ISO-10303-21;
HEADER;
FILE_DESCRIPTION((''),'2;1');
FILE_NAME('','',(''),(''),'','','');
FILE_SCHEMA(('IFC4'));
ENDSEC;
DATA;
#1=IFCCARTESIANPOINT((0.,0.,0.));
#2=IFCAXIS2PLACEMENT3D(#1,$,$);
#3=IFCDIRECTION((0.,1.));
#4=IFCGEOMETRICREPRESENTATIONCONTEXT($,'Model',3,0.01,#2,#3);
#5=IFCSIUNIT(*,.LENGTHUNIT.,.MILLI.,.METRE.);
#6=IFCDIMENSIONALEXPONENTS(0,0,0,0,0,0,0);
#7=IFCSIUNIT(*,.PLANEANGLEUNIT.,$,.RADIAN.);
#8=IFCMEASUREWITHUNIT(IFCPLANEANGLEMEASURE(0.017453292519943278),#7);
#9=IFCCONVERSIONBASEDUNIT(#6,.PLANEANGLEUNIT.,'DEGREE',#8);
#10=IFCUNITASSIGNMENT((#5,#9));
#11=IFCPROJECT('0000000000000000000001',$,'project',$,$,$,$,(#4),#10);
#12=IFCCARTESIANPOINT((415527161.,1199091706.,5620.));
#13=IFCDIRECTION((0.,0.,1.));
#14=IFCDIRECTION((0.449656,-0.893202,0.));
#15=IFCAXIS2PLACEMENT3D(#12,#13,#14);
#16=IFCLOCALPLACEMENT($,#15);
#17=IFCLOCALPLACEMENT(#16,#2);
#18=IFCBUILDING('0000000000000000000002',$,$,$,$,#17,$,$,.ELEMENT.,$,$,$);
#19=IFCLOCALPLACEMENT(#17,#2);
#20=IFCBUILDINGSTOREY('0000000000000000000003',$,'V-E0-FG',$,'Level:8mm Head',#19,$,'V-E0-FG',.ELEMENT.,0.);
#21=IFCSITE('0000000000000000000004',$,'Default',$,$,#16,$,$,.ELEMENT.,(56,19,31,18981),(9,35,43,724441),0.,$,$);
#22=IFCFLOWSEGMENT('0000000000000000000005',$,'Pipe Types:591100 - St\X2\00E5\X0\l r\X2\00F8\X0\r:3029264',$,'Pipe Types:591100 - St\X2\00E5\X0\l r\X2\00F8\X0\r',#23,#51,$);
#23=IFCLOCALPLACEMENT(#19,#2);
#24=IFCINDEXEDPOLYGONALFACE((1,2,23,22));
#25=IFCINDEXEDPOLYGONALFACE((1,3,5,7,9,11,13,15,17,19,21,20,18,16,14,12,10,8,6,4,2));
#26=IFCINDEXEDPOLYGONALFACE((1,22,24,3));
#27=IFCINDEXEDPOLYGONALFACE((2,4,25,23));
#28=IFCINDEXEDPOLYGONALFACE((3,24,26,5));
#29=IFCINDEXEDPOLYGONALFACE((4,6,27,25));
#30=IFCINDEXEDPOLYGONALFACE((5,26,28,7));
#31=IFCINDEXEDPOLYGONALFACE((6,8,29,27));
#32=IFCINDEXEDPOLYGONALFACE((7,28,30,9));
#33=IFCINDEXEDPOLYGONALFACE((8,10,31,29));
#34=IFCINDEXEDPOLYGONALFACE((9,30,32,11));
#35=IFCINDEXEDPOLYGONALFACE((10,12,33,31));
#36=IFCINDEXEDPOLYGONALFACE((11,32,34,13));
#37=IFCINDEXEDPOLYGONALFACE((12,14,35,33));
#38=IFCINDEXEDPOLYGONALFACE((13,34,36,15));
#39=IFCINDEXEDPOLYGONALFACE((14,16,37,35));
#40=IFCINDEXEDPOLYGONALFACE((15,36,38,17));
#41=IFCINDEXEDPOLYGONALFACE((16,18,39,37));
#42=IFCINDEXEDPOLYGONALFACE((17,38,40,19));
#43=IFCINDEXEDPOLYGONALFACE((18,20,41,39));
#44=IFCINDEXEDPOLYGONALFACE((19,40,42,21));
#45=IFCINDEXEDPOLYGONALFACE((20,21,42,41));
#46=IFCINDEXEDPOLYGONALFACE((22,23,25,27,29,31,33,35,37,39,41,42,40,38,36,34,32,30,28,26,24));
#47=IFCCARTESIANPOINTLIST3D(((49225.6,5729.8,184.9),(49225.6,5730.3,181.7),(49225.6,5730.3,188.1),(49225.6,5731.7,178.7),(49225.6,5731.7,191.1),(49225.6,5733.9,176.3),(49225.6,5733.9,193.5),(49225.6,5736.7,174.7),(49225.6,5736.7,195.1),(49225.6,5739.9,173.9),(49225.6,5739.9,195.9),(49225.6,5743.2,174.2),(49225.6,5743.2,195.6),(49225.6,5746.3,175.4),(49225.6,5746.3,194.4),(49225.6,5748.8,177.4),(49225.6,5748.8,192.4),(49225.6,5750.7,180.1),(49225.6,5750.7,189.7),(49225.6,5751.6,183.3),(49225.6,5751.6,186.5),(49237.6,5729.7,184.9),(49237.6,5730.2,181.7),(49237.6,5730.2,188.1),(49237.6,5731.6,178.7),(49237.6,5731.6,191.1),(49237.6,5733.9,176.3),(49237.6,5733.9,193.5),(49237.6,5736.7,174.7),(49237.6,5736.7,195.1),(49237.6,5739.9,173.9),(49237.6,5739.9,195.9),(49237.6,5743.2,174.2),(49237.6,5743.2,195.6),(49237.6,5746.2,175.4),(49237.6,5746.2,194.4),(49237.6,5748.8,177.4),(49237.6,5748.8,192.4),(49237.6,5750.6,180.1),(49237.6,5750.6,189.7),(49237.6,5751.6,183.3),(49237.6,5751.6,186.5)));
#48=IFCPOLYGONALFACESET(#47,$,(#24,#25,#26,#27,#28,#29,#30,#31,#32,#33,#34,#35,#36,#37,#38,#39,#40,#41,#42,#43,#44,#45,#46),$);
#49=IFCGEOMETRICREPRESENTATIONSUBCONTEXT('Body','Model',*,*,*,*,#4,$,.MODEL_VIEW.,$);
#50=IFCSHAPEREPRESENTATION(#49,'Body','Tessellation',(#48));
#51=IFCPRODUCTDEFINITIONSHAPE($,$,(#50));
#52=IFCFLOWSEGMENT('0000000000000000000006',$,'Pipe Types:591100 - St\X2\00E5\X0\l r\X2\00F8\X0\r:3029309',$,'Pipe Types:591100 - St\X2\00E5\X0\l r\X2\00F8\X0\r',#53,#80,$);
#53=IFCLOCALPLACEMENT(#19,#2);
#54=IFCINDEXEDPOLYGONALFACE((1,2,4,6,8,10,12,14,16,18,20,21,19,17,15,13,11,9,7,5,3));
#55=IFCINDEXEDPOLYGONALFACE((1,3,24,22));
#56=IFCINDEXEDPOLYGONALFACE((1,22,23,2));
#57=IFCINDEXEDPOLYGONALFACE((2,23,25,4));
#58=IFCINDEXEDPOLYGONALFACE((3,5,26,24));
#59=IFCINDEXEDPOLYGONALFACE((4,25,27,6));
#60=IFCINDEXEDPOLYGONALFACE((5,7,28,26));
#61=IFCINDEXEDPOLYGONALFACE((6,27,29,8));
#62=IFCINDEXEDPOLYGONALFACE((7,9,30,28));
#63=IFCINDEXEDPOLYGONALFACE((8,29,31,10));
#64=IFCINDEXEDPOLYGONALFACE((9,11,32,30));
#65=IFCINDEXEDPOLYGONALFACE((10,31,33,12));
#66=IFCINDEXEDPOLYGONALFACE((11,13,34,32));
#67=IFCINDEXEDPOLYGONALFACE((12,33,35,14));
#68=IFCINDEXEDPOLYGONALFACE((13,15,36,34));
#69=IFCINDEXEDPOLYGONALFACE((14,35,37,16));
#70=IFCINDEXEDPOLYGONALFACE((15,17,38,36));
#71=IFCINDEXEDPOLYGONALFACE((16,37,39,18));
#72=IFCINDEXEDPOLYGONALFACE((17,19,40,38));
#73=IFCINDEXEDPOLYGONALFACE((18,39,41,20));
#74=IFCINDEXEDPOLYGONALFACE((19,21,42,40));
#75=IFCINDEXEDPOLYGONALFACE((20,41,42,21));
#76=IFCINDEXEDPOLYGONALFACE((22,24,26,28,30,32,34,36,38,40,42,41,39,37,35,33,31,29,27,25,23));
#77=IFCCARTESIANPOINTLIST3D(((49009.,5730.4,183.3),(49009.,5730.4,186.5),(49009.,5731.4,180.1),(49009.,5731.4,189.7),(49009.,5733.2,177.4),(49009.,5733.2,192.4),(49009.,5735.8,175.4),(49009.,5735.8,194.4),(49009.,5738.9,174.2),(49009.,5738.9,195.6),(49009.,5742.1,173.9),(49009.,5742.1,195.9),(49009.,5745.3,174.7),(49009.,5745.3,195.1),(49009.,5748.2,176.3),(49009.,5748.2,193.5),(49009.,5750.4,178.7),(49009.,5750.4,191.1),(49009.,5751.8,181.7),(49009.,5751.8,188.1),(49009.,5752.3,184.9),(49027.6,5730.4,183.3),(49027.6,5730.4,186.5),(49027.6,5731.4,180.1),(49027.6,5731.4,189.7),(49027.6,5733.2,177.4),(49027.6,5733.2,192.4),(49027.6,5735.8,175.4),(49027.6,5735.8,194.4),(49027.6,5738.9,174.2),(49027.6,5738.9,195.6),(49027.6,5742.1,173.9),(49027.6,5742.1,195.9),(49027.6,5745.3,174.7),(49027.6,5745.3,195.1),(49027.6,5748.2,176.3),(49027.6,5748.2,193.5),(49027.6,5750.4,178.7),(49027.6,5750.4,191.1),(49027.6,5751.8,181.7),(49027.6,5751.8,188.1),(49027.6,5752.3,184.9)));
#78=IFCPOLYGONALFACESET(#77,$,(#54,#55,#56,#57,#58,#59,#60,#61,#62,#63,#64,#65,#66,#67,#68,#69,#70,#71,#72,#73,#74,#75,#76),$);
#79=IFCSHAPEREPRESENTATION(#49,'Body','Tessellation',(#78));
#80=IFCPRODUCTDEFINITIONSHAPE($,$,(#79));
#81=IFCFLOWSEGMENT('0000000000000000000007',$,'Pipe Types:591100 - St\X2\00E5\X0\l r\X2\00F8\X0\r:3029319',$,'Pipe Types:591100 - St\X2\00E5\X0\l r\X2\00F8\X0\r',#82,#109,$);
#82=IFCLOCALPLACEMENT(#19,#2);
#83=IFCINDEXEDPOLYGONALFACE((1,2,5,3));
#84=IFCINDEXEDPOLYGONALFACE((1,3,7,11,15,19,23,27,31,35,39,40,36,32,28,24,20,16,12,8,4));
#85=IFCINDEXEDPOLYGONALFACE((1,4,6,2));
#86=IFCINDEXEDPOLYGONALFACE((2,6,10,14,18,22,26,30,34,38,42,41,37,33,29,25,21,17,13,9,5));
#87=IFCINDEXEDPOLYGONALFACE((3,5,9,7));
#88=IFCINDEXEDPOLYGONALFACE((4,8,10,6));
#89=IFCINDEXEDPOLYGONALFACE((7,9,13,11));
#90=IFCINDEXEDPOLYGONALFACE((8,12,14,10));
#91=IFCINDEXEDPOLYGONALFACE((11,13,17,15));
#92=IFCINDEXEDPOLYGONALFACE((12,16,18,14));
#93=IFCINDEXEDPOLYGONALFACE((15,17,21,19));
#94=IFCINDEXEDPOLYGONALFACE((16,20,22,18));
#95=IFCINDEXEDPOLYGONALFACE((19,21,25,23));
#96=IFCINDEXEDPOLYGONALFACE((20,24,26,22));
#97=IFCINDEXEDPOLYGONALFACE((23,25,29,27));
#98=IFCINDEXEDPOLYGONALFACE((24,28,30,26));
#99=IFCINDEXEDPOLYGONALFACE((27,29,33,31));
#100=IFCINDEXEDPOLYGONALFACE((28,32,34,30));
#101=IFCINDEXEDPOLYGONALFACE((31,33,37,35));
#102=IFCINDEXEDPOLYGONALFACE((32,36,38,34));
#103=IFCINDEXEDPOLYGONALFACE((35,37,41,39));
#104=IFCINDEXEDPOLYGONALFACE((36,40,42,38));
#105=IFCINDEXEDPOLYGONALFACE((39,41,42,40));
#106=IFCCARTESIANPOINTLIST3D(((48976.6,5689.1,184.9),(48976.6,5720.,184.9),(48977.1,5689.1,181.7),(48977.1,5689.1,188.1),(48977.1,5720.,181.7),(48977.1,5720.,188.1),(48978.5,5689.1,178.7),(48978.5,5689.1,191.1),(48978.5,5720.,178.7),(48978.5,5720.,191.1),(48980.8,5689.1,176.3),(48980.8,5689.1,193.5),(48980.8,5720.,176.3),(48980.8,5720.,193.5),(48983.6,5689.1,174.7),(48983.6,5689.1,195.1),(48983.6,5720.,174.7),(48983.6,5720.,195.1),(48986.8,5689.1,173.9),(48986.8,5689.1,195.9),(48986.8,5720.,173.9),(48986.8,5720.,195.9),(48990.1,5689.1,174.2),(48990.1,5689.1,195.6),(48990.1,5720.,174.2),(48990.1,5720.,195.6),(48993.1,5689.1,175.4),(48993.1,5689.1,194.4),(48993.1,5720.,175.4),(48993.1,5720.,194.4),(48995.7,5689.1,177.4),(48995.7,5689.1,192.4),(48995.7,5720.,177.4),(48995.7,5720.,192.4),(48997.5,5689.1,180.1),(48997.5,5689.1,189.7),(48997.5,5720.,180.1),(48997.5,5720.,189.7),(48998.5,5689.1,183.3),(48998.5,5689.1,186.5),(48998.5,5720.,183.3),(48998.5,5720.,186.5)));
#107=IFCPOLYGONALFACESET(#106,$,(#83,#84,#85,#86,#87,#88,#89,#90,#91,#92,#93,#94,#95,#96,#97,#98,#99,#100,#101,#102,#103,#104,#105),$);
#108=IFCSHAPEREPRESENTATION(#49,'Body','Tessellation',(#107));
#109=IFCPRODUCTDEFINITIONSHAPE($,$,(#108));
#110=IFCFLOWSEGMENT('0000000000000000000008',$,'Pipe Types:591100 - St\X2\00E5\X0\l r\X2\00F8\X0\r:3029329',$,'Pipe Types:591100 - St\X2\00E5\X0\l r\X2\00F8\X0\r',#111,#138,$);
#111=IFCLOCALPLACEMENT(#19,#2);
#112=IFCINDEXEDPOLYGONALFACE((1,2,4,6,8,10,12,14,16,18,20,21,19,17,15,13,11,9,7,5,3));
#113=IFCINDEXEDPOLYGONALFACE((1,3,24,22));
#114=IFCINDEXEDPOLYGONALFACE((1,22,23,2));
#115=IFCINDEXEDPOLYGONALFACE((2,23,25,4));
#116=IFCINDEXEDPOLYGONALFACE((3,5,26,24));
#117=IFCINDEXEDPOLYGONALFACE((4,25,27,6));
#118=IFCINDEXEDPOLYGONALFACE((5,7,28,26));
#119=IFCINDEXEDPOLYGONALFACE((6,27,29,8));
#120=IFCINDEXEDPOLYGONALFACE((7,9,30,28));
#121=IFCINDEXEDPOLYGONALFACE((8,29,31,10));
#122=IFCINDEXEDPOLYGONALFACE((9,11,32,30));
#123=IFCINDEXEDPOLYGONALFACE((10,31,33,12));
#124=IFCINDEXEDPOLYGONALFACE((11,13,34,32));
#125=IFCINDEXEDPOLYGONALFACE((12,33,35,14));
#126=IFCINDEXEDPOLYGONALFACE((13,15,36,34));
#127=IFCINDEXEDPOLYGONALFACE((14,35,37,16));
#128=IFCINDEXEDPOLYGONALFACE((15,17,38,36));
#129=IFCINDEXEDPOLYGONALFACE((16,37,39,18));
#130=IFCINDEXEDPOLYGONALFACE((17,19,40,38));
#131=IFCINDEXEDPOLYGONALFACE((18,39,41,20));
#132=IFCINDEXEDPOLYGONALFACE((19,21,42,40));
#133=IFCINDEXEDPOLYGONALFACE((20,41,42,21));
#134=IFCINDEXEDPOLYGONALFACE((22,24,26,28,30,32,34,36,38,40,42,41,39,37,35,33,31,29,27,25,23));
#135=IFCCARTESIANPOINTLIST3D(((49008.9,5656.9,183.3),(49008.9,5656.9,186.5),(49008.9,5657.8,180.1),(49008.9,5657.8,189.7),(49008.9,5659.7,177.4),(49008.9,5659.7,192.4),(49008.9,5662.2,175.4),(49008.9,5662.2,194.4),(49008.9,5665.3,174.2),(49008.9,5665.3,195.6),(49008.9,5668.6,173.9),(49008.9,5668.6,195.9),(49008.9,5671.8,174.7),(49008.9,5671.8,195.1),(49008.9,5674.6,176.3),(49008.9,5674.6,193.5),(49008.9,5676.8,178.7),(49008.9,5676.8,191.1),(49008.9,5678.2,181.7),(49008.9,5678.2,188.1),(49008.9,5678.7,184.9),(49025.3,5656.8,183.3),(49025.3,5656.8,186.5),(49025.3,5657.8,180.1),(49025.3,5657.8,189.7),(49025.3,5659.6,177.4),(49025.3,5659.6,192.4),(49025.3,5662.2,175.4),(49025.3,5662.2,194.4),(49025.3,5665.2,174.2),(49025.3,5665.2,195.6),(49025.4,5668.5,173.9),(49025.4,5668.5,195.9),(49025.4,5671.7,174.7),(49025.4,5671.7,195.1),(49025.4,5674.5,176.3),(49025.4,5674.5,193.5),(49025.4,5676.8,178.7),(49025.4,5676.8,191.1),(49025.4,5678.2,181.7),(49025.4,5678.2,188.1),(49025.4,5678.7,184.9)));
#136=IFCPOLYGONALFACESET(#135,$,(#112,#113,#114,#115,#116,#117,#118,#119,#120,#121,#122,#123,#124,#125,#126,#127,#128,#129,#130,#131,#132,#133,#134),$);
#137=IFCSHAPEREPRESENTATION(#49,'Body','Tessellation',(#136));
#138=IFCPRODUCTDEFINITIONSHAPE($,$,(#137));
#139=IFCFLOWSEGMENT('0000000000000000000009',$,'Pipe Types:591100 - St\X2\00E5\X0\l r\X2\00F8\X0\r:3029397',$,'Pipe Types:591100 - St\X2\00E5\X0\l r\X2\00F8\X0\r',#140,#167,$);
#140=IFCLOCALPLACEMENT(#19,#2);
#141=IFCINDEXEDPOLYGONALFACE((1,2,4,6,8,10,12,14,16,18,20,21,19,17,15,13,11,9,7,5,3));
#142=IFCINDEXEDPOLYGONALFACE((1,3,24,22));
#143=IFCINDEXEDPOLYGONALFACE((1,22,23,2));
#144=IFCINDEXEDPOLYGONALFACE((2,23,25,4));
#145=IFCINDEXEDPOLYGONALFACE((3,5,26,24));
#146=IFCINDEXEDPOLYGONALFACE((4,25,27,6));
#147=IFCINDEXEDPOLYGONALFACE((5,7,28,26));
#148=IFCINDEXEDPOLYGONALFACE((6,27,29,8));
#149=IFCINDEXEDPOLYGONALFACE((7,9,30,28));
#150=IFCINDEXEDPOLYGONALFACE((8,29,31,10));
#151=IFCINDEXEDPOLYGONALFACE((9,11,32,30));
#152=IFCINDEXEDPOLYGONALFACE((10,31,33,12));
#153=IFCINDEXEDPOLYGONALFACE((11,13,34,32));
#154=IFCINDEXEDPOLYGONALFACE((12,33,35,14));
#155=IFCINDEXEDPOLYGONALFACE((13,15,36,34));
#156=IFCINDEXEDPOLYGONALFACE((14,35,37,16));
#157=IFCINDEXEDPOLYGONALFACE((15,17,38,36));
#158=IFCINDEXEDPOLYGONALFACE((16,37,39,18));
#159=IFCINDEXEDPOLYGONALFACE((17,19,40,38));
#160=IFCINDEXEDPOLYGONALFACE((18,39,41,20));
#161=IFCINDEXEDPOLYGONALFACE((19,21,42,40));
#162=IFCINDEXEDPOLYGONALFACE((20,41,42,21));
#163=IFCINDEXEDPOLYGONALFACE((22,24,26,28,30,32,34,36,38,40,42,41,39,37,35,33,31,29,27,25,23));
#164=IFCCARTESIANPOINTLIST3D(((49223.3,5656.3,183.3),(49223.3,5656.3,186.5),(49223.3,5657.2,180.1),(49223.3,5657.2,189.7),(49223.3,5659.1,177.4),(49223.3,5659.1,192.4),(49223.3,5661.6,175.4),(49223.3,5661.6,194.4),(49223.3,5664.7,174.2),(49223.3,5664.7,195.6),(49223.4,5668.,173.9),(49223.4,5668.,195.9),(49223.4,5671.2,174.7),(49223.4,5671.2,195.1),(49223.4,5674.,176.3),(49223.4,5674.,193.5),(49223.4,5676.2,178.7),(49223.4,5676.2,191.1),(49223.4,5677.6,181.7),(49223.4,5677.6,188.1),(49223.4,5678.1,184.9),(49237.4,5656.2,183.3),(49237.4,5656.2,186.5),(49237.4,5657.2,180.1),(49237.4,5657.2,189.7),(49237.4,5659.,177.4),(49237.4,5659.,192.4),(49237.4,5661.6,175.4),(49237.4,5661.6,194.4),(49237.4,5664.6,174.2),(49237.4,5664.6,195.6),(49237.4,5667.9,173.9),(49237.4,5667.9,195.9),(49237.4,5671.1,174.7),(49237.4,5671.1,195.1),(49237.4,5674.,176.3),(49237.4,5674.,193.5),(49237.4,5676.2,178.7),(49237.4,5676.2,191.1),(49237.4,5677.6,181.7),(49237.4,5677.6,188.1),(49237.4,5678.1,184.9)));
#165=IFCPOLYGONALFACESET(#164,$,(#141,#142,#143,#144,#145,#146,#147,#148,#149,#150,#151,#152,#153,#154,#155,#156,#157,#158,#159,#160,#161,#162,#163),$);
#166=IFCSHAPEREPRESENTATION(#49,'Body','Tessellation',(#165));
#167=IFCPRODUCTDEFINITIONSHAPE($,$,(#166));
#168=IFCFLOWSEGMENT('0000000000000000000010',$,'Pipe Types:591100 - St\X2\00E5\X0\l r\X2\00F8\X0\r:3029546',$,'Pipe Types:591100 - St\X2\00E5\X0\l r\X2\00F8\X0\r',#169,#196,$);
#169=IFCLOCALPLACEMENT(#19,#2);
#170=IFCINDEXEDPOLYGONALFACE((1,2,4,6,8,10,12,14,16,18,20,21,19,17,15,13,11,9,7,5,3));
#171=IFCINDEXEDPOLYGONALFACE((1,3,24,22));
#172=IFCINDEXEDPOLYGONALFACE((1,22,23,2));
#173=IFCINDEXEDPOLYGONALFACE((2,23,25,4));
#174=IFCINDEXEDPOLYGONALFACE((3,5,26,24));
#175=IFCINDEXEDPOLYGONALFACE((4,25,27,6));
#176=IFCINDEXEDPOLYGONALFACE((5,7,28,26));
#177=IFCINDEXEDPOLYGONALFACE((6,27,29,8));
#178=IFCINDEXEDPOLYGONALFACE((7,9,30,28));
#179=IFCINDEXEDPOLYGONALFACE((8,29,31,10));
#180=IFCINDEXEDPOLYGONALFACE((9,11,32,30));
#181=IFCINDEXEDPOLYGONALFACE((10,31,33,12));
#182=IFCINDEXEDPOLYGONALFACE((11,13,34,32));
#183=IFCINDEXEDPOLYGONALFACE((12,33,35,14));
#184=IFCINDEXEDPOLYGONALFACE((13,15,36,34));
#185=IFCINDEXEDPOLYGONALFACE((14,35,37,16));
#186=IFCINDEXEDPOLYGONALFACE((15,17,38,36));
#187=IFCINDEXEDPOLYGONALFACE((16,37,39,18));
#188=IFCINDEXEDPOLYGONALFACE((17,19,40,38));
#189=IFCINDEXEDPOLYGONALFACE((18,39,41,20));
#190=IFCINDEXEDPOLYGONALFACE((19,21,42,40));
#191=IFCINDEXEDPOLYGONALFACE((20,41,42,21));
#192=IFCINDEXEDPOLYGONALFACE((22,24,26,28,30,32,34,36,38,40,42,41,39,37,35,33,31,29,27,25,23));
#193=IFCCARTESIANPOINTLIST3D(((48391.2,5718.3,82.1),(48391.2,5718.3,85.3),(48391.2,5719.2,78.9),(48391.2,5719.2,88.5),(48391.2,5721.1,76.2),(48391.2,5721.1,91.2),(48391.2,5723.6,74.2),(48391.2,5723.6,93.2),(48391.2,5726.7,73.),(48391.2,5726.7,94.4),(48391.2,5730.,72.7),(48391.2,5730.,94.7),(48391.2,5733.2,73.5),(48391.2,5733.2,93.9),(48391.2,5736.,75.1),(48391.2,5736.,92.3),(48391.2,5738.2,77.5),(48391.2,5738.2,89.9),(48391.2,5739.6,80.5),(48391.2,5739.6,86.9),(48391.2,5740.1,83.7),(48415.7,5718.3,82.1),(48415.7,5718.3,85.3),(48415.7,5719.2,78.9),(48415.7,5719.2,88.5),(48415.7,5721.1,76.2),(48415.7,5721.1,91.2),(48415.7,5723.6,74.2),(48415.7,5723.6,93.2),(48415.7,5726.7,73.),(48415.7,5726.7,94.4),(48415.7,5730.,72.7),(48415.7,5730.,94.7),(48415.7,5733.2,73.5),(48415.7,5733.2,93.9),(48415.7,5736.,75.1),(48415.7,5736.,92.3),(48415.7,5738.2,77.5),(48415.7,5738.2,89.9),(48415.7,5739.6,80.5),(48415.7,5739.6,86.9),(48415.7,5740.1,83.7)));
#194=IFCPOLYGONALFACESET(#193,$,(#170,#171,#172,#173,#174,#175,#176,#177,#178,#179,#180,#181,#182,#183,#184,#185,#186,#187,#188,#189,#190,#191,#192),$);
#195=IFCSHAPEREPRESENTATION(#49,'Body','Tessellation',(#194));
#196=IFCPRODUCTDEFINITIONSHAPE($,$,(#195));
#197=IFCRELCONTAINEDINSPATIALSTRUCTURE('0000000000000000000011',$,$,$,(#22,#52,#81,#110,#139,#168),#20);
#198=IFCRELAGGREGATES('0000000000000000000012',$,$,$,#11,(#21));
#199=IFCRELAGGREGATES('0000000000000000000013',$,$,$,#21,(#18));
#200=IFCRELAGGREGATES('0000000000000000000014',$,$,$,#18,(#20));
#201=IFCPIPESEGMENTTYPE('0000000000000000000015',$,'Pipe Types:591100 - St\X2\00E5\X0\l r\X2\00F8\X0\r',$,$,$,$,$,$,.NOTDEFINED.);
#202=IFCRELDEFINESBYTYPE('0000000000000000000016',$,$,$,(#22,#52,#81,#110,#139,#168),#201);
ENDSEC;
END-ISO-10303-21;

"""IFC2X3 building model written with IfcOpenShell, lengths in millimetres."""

from ifc_helpers import new_model, entity, si_unit, converted_unit, direction, frame, frame_2d, origin, origin_2d_with_axis, place, context, subcontext, project, spatial, circle, extrude, type_object, element, save


model = new_model("IFC2X3")

# Units and contexts
model_context = context("Model", 3, precision=0.01, world=origin(), true_north=direction((0.0, 1.0)))
body_context = subcontext(model_context, "Body", "Model", "MODEL_VIEW")
ifc_project = project(units=[si_unit("LENGTHUNIT", "METRE", prefix="MILLI"), converted_unit("PLANEANGLEUNIT", "DEGREE", entity("IfcPlaneAngleMeasure", 0.017453292519943278), si_unit("PLANEANGLEUNIT", "RADIAN"), dimensions=[0, 0, 0, 0, 0, 0, 0])], contexts=[model_context])

# Site, building, storey
site_placement = place(None, frame((415527161.0, 1199091706.0, 5620.0), z_axis=(0.0, 0.0, 1.0), x_axis=(0.449656, -0.893202, 0.0)))
site = spatial("IfcSite", under=ifc_project, at=site_placement, Name="Default", CompositionType="ELEMENT", RefLatitude=(56, 19, 31, 18981), RefLongitude=(9, 35, 43, 724441), RefElevation=0.0)
building_placement = place(site_placement, origin())
building = spatial("IfcBuilding", under=site, at=building_placement, CompositionType="ELEMENT")
storey_placement = place(building_placement, origin())
storey = spatial("IfcBuildingStorey", under=building, at=storey_placement, Name="V-E0-FG", ObjectType="Level:8mm Head", LongName="V-E0-FG", CompositionType="ELEMENT", Elevation=0.0)

# Flow segments
pipe_segment_type_1 = type_object("IfcPipeSegmentType", Name="Pipe Types:591100 - Stål rør", PredefinedType="NOTDEFINED")
flow_segment_1_placement = place(storey_placement, origin())
element("IfcFlowSegment", 1, at=flow_segment_1_placement, inside=storey, type_object=pipe_segment_type_1, Name="Pipe Types:591100 - Stål rør:3029264", ObjectType="Pipe Types:591100 - Stål rør", context=body_context, shape_type="SweptSolid", body=[
    extrude(circle(Radius=11.0, at=origin_2d_with_axis()), frame((49225.6, 5740.8, 184.9), z_axis=(0.999996, -0.002778, 0.0), x_axis=(-0.002778, -0.999996, 0.0)), (0.0, 0.0, 1.0), 12.0),
])
flow_segment_2_placement = place(storey_placement, origin())
element("IfcFlowSegment", 2, at=flow_segment_2_placement, inside=storey, type_object=pipe_segment_type_1, Name="Pipe Types:591100 - Stål rør:3029309", ObjectType="Pipe Types:591100 - Stål rør", context=body_context, shape_type="SweptSolid", body=[
    extrude(circle(Radius=11.0, at=frame_2d((0.0, 0.0), x_axis=(1.0, 0.0))), frame((49009.0, 5741.3, 184.9), z_axis=(1.0, 0.0, 0.0), x_axis=(0.0, 1.0, 0.0)), (0.0, 0.0, 1.0), 18.7),
])
flow_segment_3_placement = place(storey_placement, origin())
element("IfcFlowSegment", 3, at=flow_segment_3_placement, inside=storey, type_object=pipe_segment_type_1, Name="Pipe Types:591100 - Stål rør:3029319", ObjectType="Pipe Types:591100 - Stål rør", context=body_context, shape_type="SweptSolid", body=[
    extrude(circle(Radius=11.0, at=frame_2d((0.0, 0.0), x_axis=(1.0, 0.0))), frame((48987.6, 5689.1, 184.9), z_axis=(0.0, 1.0, 0.0), x_axis=(-1.0, 0.0, 0.0)), (0.0, 0.0, 1.0), 30.9),
])
flow_segment_4_placement = place(storey_placement, origin())
element("IfcFlowSegment", 4, at=flow_segment_4_placement, inside=storey, type_object=pipe_segment_type_1, Name="Pipe Types:591100 - Stål rør:3029329", ObjectType="Pipe Types:591100 - Stål rør", context=body_context, shape_type="SweptSolid", body=[
    extrude(circle(Radius=11.0, at=origin_2d_with_axis()), frame((49008.9, 5667.7, 184.9), z_axis=(0.999996, -0.002778, 0.0), x_axis=(0.002778, 0.999996, 0.0)), (0.0, 0.0, 1.0), 16.4),
])
flow_segment_5_placement = place(storey_placement, origin())
element("IfcFlowSegment", 5, at=flow_segment_5_placement, inside=storey, type_object=pipe_segment_type_1, Name="Pipe Types:591100 - Stål rør:3029397", ObjectType="Pipe Types:591100 - Stål rør", context=body_context, shape_type="SweptSolid", body=[
    extrude(circle(Radius=11.0, at=origin_2d_with_axis()), frame((49223.4, 5667.1, 184.9), z_axis=(0.999996, -0.002778, 0.0), x_axis=(0.002778, 0.999996, 0.0)), (0.0, 0.0, 1.0), 14.1),
])
flow_segment_6_placement = place(storey_placement, origin())
element("IfcFlowSegment", 6, at=flow_segment_6_placement, inside=storey, type_object=pipe_segment_type_1, Name="Pipe Types:591100 - Stål rør:3029546", ObjectType="Pipe Types:591100 - Stål rør", context=body_context, shape_type="SweptSolid", body=[
    extrude(circle(Radius=11.0, at=origin_2d_with_axis()), frame((48391.2, 5729.1, 83.7), z_axis=(1.0, 0.0, 0.0), x_axis=(0.0, 1.0, 0.0)), (0.0, 0.0, 1.0), 24.5),
])

save(model, "model.ifc")
